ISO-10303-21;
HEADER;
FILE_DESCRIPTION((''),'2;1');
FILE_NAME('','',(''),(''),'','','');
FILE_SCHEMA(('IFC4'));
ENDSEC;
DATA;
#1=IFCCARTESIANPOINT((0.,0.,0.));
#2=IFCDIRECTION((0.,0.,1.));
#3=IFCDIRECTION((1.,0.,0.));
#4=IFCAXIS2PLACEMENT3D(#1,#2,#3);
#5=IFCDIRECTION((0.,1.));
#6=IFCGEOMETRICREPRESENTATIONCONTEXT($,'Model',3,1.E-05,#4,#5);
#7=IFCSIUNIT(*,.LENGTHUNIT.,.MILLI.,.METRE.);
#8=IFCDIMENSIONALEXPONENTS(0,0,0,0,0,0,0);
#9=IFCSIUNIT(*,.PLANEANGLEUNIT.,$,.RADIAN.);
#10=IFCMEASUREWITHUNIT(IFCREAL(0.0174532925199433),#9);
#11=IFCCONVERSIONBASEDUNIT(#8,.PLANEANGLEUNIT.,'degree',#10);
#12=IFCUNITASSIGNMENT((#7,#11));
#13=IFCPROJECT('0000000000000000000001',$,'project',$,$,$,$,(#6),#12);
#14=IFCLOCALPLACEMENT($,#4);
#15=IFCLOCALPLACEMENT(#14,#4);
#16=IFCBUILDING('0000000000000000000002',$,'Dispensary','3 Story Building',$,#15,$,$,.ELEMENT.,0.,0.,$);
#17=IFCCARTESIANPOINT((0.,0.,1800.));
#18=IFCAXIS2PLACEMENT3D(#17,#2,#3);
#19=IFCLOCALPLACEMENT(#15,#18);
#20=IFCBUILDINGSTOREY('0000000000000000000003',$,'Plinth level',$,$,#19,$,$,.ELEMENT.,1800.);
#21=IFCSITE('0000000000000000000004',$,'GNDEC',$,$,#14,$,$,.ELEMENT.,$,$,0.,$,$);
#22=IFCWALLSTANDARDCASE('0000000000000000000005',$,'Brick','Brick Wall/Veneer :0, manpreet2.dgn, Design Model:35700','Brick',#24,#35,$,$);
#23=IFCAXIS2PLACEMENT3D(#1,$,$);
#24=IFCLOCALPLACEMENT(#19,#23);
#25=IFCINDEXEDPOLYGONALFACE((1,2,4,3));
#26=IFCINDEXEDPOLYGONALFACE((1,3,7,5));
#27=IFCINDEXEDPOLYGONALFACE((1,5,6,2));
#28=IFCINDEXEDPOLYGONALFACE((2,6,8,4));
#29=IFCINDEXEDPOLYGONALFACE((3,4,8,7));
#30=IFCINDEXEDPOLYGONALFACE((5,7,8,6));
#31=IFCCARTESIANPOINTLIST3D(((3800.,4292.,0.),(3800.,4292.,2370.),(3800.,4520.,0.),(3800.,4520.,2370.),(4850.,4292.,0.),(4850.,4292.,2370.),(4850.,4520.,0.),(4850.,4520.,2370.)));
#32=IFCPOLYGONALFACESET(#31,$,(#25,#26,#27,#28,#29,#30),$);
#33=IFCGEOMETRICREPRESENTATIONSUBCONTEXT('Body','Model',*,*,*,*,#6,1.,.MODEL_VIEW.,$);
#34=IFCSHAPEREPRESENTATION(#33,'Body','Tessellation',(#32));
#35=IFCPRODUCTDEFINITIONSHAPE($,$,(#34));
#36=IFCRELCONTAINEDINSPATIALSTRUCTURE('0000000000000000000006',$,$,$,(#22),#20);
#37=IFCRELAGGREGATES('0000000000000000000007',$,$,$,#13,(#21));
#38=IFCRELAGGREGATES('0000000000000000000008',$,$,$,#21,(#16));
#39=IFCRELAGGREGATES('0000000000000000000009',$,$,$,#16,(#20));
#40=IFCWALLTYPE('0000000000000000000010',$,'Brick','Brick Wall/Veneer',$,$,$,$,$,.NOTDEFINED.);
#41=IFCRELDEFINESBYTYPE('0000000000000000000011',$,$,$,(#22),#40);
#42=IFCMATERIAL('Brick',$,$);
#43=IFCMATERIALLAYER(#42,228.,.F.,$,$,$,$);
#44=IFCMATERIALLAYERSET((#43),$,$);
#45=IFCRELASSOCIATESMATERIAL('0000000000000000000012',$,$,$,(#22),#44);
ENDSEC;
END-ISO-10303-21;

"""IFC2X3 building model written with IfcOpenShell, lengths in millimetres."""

from ifc_helpers import new_model, entity, si_unit, converted_unit, direction, frame, frame_2d, origin_with_axes, place, context, subcontext, project, spatial, rectangle, extrude, material, layer, layer_set, layer_usage, type_object, element, save


model = new_model("IFC2X3")

# Units and contexts
model_context = context("Model", 3, precision=1e-05, world=origin_with_axes(), true_north=direction((0.0, 1.0)))
body_context = subcontext(model_context, "Body", "Model", "MODEL_VIEW", scale=1.0)
ifc_project = project(units=[si_unit("LENGTHUNIT", "METRE", prefix="MILLI"), converted_unit("PLANEANGLEUNIT", "degree", entity("IfcReal", 0.0174532925199433), si_unit("PLANEANGLEUNIT", "RADIAN"), dimensions=[0, 0, 0, 0, 0, 0, 0])], contexts=[model_context])

# Site, building, storey
site_placement = place(None, origin_with_axes())
site = spatial("IfcSite", under=ifc_project, at=site_placement, Name="GNDEC", CompositionType="ELEMENT", RefElevation=0.0)
building_placement = place(site_placement, origin_with_axes())
building = spatial("IfcBuilding", under=site, at=building_placement, Name="Dispensary", Description="3 Story Building", CompositionType="ELEMENT", ElevationOfRefHeight=0.0, ElevationOfTerrain=0.0)
storey_placement = place(building_placement, frame((0.0, 0.0, 1800.0), z_axis=(0.0, 0.0, 1.0), x_axis=(1.0, 0.0, 0.0)))
storey = spatial("IfcBuildingStorey", under=building, at=storey_placement, Name="Plinth level", CompositionType="ELEMENT", Elevation=1800.0)

# Wall
ifc_material_1 = material(Name="Brick")
ifc_layer = layer(ifc_material_1, 228.0, ventilated=False)
ifc_layer_set = layer_set([ifc_layer])
ifc_layer_usage = layer_usage(ifc_layer_set, "AXIS2", "POSITIVE", 0.0)
wall_type = type_object("IfcWallType", Name="Brick", Description="Brick Wall/Veneer", PredefinedType="NOTDEFINED")
wall_1_placement = place(storey_placement, frame((3800.0, 4520.0, 0.0), z_axis=(0.0, 0.0, 1.0), x_axis=(1.0, 0.0, 0.0)))
element("IfcWallStandardCase", 1, at=wall_1_placement, inside=storey, type_object=wall_type, material=ifc_layer_usage, Name="Brick", Description="Brick Wall/Veneer :0, manpreet2.dgn, Design Model:35700", ObjectType="Brick", context=body_context, shape_type="SweptSolid", body=[
    extrude(rectangle(XDim=1050.0, YDim=228.0, at=frame_2d((525.0, -114.0), x_axis=(-1.0, 0.0))), origin_with_axes(), (0.0, 0.0, 1.0), 2370.0),
])

save(model, "model.ifc")
